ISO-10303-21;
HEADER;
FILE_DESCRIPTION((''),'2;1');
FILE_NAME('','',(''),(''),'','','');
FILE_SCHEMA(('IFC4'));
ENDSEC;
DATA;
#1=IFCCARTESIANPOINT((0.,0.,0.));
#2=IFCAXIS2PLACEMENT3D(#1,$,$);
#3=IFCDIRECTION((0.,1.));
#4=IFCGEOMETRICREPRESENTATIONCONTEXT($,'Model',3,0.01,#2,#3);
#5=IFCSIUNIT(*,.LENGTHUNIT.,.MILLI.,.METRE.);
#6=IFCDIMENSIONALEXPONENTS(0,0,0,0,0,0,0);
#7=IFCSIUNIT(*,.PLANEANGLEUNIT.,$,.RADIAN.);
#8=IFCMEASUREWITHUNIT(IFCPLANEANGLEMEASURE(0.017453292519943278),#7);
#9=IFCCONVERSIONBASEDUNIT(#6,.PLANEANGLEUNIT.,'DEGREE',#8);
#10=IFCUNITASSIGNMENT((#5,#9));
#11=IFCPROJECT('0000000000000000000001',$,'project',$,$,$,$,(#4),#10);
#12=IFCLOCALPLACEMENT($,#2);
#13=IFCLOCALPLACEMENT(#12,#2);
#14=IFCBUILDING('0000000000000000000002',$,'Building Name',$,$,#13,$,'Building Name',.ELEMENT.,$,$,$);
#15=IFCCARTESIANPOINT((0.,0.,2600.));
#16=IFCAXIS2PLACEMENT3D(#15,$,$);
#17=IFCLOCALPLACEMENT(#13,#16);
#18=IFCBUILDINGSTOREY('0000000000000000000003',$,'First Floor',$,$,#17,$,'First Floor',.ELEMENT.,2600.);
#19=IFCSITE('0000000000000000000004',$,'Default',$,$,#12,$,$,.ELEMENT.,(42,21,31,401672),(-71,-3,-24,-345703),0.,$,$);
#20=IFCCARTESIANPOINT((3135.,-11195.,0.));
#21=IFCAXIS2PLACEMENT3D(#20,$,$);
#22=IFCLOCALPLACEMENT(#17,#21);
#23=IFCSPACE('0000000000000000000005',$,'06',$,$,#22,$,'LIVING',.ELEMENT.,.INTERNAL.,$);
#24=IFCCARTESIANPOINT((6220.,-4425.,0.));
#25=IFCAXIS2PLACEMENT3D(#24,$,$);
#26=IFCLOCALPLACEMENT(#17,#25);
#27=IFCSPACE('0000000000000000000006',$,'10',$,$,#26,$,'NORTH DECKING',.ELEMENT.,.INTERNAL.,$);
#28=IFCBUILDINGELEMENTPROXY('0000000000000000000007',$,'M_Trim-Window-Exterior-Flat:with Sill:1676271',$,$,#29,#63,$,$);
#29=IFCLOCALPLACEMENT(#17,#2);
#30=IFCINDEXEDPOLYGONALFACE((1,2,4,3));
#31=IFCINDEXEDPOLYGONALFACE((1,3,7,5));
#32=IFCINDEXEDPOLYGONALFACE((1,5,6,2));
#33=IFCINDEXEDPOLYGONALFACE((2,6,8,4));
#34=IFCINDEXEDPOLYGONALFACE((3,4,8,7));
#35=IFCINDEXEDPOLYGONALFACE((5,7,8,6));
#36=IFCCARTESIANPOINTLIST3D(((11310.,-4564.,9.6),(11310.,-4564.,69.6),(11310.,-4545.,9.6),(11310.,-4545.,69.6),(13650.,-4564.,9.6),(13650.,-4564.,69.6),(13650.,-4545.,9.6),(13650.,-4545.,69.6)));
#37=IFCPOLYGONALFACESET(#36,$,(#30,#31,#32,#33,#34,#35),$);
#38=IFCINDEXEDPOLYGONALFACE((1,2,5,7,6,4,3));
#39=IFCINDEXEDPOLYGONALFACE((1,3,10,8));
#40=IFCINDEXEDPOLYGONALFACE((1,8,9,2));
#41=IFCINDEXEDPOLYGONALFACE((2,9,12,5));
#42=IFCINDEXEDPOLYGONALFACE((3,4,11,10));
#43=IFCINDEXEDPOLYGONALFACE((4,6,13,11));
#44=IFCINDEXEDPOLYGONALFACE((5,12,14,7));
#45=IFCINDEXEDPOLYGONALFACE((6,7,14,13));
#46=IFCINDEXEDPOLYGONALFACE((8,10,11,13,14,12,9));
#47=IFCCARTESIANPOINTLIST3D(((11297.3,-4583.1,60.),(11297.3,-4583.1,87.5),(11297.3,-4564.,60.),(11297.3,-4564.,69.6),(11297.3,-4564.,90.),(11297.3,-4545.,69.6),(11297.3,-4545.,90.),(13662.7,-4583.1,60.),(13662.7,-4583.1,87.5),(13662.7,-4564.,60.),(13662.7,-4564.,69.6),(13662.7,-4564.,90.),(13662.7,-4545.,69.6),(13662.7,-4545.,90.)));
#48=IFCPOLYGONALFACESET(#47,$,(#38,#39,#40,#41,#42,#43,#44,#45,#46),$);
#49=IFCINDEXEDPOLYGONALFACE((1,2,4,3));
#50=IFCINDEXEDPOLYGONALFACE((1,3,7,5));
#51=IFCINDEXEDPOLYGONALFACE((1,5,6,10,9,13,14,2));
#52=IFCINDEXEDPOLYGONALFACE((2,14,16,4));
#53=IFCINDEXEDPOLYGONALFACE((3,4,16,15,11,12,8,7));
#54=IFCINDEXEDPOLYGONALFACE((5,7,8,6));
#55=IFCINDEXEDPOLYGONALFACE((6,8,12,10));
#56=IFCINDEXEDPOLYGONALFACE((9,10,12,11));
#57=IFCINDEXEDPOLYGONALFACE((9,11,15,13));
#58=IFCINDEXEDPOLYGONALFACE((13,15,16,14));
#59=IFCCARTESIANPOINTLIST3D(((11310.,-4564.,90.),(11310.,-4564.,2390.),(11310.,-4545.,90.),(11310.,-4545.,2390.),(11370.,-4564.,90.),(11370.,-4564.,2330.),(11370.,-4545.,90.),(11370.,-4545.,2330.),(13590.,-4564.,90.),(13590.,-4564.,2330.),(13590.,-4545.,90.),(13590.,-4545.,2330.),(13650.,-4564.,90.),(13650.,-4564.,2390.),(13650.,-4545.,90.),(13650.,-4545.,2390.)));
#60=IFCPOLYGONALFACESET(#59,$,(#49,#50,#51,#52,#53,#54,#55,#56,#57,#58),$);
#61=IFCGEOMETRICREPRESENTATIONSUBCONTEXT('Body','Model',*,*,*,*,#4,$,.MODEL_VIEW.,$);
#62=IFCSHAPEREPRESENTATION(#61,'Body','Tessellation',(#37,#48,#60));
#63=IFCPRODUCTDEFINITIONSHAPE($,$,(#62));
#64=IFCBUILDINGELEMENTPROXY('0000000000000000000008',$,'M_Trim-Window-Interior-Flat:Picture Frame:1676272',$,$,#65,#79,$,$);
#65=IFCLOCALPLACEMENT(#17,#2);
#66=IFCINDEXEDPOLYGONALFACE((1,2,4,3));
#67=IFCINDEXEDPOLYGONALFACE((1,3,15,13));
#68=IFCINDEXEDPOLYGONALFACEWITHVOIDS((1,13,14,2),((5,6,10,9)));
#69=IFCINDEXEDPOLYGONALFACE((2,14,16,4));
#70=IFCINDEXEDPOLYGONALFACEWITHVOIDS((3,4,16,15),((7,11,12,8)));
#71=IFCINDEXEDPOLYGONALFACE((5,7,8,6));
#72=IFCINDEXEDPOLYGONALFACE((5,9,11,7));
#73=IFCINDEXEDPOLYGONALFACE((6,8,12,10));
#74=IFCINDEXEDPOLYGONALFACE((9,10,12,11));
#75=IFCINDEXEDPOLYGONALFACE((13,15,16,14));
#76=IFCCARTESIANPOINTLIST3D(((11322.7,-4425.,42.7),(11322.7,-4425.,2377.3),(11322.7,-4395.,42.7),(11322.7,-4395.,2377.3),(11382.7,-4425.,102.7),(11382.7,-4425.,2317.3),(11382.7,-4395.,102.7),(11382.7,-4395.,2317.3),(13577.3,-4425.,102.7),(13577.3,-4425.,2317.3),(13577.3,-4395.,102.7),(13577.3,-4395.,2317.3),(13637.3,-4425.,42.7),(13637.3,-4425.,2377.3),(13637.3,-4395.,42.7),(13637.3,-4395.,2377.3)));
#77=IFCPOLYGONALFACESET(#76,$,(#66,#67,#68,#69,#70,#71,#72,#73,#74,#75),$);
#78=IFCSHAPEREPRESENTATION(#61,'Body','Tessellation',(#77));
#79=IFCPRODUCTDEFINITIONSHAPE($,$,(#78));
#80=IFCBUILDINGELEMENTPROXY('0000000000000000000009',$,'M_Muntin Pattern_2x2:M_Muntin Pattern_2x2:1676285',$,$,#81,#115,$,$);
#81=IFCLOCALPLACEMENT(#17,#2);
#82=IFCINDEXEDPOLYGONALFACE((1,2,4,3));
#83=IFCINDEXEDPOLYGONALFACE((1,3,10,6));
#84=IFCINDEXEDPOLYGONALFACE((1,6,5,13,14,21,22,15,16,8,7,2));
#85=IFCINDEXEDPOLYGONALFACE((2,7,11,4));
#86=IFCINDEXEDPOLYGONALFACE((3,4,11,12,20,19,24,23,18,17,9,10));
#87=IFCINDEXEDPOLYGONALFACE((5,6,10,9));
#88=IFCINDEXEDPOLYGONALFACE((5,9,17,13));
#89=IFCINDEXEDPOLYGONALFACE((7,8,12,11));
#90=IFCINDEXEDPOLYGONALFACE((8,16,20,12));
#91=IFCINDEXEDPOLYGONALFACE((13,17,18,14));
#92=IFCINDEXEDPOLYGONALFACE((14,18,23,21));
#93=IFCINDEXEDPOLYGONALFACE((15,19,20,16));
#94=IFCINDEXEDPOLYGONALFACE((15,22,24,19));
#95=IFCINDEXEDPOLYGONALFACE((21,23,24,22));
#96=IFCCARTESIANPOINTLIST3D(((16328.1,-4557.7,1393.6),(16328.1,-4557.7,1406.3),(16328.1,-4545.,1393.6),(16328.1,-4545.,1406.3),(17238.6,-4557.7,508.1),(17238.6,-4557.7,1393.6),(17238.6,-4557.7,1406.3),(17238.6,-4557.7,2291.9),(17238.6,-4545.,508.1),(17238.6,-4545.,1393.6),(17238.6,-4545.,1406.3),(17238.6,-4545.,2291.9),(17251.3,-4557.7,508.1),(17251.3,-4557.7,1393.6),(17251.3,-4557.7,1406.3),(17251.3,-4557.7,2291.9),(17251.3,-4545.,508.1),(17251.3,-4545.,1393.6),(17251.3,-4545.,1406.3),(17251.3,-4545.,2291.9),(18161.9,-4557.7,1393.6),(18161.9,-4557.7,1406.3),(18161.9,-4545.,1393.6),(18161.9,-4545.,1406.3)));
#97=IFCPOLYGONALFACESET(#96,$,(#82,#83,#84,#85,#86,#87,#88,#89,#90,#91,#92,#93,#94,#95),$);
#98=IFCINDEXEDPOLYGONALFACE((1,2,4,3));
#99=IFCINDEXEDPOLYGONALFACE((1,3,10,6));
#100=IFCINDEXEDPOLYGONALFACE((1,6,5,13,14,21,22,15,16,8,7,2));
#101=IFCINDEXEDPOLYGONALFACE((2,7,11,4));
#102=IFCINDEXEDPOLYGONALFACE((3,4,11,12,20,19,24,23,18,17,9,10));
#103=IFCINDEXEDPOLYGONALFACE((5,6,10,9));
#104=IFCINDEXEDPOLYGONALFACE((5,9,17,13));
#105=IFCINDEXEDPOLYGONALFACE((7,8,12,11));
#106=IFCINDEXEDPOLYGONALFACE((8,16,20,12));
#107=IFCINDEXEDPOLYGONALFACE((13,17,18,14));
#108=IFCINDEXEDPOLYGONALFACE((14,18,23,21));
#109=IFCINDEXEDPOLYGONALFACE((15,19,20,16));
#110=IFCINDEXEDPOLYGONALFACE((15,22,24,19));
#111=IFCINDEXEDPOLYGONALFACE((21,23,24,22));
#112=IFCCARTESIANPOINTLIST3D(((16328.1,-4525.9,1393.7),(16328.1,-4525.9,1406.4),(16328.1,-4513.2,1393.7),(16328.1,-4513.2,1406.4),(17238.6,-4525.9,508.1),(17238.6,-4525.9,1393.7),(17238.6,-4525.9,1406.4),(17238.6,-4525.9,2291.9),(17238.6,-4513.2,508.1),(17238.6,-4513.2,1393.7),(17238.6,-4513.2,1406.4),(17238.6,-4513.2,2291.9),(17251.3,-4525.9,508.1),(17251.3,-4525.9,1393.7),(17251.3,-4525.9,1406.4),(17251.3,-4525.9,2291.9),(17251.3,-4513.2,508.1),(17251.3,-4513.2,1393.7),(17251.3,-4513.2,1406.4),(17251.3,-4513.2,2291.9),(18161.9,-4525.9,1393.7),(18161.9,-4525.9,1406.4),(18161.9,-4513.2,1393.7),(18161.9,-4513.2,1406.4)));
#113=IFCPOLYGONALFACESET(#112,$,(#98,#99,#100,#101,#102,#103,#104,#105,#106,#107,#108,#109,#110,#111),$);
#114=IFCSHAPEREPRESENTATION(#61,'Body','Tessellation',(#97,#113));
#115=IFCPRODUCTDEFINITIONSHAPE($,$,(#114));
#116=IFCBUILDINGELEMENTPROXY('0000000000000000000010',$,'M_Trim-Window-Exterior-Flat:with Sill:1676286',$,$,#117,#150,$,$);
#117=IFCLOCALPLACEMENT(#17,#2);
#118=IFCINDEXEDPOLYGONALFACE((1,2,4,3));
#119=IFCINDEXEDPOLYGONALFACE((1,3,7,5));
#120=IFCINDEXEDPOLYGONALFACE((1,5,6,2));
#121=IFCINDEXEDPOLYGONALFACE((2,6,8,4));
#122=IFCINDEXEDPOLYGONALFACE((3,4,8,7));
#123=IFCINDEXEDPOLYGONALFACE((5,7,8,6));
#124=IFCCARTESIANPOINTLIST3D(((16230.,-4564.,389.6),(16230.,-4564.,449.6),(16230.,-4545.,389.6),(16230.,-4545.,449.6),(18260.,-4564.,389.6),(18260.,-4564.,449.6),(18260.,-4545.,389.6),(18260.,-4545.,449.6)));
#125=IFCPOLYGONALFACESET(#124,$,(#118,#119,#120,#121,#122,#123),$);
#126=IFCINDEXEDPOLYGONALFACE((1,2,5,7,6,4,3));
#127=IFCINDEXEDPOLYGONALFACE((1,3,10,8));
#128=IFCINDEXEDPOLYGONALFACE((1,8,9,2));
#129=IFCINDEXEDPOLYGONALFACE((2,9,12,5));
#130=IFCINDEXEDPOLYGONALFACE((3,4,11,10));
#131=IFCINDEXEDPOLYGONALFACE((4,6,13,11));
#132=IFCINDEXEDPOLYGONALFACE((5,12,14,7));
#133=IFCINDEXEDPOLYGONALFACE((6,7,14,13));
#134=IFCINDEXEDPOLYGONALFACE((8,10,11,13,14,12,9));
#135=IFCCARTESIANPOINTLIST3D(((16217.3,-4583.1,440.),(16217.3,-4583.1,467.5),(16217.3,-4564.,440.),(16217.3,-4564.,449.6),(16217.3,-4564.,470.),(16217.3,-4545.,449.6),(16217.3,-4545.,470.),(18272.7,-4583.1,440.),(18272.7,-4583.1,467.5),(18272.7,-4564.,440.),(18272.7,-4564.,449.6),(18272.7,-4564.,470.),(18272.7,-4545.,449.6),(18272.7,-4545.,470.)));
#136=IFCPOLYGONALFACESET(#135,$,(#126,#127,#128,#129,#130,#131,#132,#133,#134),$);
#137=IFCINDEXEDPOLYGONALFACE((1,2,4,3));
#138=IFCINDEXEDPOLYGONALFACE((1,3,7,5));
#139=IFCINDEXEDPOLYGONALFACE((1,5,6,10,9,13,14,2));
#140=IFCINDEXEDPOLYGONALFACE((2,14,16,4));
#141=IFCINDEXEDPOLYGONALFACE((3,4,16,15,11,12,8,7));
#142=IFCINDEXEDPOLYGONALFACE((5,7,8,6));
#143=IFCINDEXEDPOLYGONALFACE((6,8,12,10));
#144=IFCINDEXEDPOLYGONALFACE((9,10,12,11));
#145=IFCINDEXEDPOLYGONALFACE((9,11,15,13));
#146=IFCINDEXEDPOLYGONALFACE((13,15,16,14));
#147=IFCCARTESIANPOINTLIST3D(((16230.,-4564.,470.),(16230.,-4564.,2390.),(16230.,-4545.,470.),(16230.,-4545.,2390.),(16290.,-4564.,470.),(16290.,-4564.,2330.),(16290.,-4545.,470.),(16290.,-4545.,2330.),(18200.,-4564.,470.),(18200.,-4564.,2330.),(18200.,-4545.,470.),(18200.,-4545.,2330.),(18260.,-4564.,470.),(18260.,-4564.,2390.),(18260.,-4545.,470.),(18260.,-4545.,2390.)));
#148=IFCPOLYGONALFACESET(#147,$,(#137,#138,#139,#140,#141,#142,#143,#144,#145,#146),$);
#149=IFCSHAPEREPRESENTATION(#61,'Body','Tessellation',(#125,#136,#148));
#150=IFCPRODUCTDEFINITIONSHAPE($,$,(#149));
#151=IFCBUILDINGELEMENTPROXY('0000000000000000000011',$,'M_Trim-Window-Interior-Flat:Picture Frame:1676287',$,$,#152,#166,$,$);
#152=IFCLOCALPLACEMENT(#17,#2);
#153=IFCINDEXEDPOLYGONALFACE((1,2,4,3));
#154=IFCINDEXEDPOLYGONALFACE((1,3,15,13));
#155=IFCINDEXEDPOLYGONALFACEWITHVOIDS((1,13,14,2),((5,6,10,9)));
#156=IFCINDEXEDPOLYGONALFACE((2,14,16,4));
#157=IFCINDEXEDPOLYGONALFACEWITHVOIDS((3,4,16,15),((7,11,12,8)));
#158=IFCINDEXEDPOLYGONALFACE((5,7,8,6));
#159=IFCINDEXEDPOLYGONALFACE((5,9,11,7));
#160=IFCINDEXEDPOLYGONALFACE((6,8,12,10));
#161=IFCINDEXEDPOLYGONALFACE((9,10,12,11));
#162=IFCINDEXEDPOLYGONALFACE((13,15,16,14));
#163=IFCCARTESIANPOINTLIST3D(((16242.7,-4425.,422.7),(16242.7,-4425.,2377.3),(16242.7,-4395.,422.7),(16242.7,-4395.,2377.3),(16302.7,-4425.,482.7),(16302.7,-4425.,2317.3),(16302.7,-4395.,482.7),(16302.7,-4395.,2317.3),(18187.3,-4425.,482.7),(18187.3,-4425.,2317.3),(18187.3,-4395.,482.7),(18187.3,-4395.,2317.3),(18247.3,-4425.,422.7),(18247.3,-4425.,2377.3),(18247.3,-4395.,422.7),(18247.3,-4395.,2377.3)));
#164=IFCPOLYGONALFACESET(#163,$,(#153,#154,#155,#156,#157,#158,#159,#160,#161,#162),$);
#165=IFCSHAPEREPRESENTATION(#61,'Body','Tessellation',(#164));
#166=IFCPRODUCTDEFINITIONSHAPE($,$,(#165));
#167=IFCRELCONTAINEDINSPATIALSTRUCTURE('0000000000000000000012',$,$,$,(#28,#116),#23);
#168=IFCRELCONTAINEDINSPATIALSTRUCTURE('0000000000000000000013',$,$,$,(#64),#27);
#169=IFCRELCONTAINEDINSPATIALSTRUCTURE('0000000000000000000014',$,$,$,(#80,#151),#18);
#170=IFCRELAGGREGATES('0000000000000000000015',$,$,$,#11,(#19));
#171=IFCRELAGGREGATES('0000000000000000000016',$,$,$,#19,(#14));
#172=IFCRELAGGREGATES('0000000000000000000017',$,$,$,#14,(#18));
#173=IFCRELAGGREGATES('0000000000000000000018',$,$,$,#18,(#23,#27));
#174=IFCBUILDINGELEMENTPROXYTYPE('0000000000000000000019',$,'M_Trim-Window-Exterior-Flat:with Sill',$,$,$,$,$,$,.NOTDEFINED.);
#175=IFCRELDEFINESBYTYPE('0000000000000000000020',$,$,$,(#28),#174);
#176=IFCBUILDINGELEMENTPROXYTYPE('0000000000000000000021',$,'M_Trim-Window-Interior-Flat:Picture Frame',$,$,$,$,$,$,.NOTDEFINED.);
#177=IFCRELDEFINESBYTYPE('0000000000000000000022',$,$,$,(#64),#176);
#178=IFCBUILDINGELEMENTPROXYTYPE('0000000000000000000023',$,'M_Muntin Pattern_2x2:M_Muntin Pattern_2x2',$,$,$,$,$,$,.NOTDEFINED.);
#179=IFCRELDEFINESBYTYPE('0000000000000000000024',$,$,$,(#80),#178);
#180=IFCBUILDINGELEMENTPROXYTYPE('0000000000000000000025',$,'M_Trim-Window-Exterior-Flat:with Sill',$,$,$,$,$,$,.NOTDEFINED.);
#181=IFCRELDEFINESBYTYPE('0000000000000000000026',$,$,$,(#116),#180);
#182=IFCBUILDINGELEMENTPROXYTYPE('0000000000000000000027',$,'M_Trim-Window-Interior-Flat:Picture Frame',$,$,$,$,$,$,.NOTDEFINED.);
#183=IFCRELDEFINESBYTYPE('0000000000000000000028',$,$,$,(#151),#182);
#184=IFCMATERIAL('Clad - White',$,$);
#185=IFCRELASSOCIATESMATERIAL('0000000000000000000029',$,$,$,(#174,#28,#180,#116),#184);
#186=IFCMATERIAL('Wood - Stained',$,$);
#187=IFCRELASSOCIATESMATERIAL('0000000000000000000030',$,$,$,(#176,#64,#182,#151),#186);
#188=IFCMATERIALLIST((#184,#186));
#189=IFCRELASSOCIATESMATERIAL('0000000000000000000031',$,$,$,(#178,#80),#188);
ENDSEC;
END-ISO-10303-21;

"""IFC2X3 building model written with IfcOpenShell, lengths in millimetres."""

from ifc_helpers import new_model, entity, si_unit, converted_unit, direction, frame, frame_2d, origin, place, context, subcontext, project, spatial, polyline, rectangle, outline, extrude, source, transform, mapped, material, material_list, type_object, type_shapes, element, save


model = new_model("IFC2X3")

# Units and contexts
model_context = context("Model", 3, precision=0.01, world=origin(), true_north=direction((0.0, 1.0)))
body_context = subcontext(model_context, "Body", "Model", "MODEL_VIEW")
ifc_project = project(units=[si_unit("LENGTHUNIT", "METRE", prefix="MILLI"), converted_unit("PLANEANGLEUNIT", "DEGREE", entity("IfcPlaneAngleMeasure", 0.017453292519943278), si_unit("PLANEANGLEUNIT", "RADIAN"), dimensions=[0, 0, 0, 0, 0, 0, 0])], contexts=[model_context])

# Site, building, storey
site_placement = place(None, origin())
site = spatial("IfcSite", under=ifc_project, at=site_placement, Name="Default", CompositionType="ELEMENT", RefLatitude=(42, 21, 31, 401672), RefLongitude=(-71, -3, -24, -345703), RefElevation=0.0)
building_placement = place(site_placement, origin())
building = spatial("IfcBuilding", under=site, at=building_placement, Name="Building Name", LongName="Building Name", CompositionType="ELEMENT")
storey_placement = place(building_placement, frame((0.0, 0.0, 2600.0)))
storey = spatial("IfcBuildingStorey", under=building, at=storey_placement, Name="First Floor", LongName="First Floor", CompositionType="ELEMENT", Elevation=2600.0)

# Shared definitions
space_1_placement = place(storey_placement, frame((3135.0, -11195.0, 0.0)))
space_1 = spatial("IfcSpace", under=storey, at=space_1_placement, Name="06", LongName="LIVING", CompositionType="ELEMENT", InteriorOrExteriorSpace="INTERNAL")

# Shared definitions
ifc_material_1 = material(Name="Clad - White")
ifc_material_2 = material(Name="Wood - Stained")
ifc_material_list_1 = material_list([ifc_material_1, ifc_material_2])

# Shared definitions
space_2_placement = place(storey_placement, frame((6220.0, -4425.0, 0.0)))
space_2 = spatial("IfcSpace", under=storey, at=space_2_placement, Name="10", LongName="NORTH DECKING", CompositionType="ELEMENT", InteriorOrExteriorSpace="INTERNAL")

# Building element proxies
building_element_proxy_type_1 = type_object("IfcBuildingElementProxyType", Name="M_Trim-Window-Exterior-Flat:with Sill", PredefinedType="NOTDEFINED", material=ifc_material_1)
shared_shape_1 = source(origin(), body_context, "Body", "SweptSolid", [
    extrude(rectangle(XDim=2340.0, YDim=60.0, at=frame_2d((0.0, 0.0), x_axis=(1.0, 0.0))), frame((0.0, -2290.4, 0.0), z_axis=(0.0, 0.0, 1.0), x_axis=(-1.0, 0.0, 0.0)), (0.0, 0.0, 1.0), 19.0),
    extrude(outline(polyline([(-19.0, -15.2), (0.0, -15.2), (0.0, -5.7), (19.0, -5.7), (19.0, 14.8), (0.0, 14.8), (-19.0, 12.3), (-19.0, -15.2)])), frame((-1182.7, -2254.8, 19.0), z_axis=(1.0, 0.0, 0.0), x_axis=(0.0, 0.0, -1.0)), (0.0, 0.0, 1.0), 2365.4),
    extrude(outline(polyline([(-1165.0, -1170.0), (1135.0, -1170.0), (1135.0, -1110.0), (-1105.0, -1110.0), (-1105.0, 1110.0), (1135.0, 1110.0), (1135.0, 1170.0), (-1165.0, 1170.0), (-1165.0, -1170.0)])), frame((0.0, -1105.0, 0.0), z_axis=(0.0, 0.0, 1.0), x_axis=(0.0, -1.0, 0.0)), (0.0, 0.0, 1.0), 19.0),
])
type_shapes(building_element_proxy_type_1, [shared_shape_1])
proxy_1_placement = place(space_1_placement, frame((9345.0, 6650.0, 2330.0), z_axis=(0.0, -1.0, 0.0), x_axis=(1.0, 0.0, 0.0)))
element("IfcBuildingElementProxy", 1, at=proxy_1_placement, inside=space_1, type_object=building_element_proxy_type_1, material=ifc_material_1, Name="M_Trim-Window-Exterior-Flat:with Sill:1676271", context=body_context, shape_type="MappedRepresentation", body=[
    mapped(shared_shape_1, transform((0.0, 0.0, 0.0), scale=1.0)),
])
building_element_proxy_type_2 = type_object("IfcBuildingElementProxyType", Name="M_Trim-Window-Interior-Flat:Picture Frame", PredefinedType="NOTDEFINED", material=ifc_material_2)
shared_shape_2 = source(origin(), body_context, "Body", "SweptSolid", [
    extrude(outline(polyline([(-1157.3, -1167.3), (1157.3, -1167.3), (1157.3, 1167.3), (-1157.3, 1167.3), (-1157.3, -1167.3)]), holes=[polyline([(-1097.3, -1107.3), (-1097.3, 1107.3), (1097.3, 1107.3), (1097.3, -1107.3), (-1097.3, -1107.3)])]), frame((0.0, -1120.0, 0.0), z_axis=(0.0, 0.0, 1.0), x_axis=(-1.0, 0.0, 0.0)), (0.0, 0.0, 1.0), 30.0),
])
type_shapes(building_element_proxy_type_2, [shared_shape_2])
proxy_2_placement = place(space_2_placement, frame((6260.0, 0.0, 2330.0), z_axis=(0.0, 1.0, 0.0), x_axis=(-1.0, 0.0, 0.0)))
element("IfcBuildingElementProxy", 2, at=proxy_2_placement, inside=space_2, type_object=building_element_proxy_type_2, material=ifc_material_2, Name="M_Trim-Window-Interior-Flat:Picture Frame:1676272", context=body_context, shape_type="MappedRepresentation", body=[
    mapped(shared_shape_2, transform((0.0, 0.0, 0.0), scale=1.0)),
])
building_element_proxy_type_3 = type_object("IfcBuildingElementProxyType", Name="M_Muntin Pattern_2x2:M_Muntin Pattern_2x2", PredefinedType="NOTDEFINED", material=ifc_material_list_1)
shared_shape_3 = source(origin(), body_context, "Body", "SweptSolid", [
    extrude(outline(polyline([(6.4, -6.4), (891.9, -6.4), (891.9, 6.3), (6.4, 6.3), (6.4, 916.9), (-6.3, 916.9), (-6.3, 6.3), (-891.9, 6.3), (-891.9, -6.4), (-6.3, -6.4), (-6.3, -916.9), (6.4, -916.9), (6.4, -6.4)])), frame((0.0, -22.2, 891.9), z_axis=(0.0, 1.0, 0.0), x_axis=(0.0, 0.0, 1.0)), (0.0, 0.0, 1.0), 12.7),
    extrude(outline(polyline([(6.4, -6.4), (891.9, -6.4), (891.9, 6.3), (6.4, 6.3), (6.4, 916.9), (-6.3, 916.9), (-6.3, 6.3), (-891.9, 6.3), (-891.9, -6.4), (-6.3, -6.4), (-6.3, -916.9), (6.4, -916.9), (6.4, -6.4)])), frame((0.0, 9.5, 891.9), z_axis=(0.0, 1.0, 0.0), x_axis=(0.0, 0.0, 1.0)), (0.0, 0.0, 1.0), 12.7),
])
type_shapes(building_element_proxy_type_3, [shared_shape_3])
proxy_3_placement = place(storey_placement, frame((17245.0, -4535.5, 508.1)))
element("IfcBuildingElementProxy", 3, at=proxy_3_placement, inside=storey, type_object=building_element_proxy_type_3, material=ifc_material_list_1, Name="M_Muntin Pattern_2x2:M_Muntin Pattern_2x2:1676285", context=body_context, shape_type="MappedRepresentation", body=[
    mapped(shared_shape_3, transform((0.0, 0.0, 0.0), scale=1.0)),
])
building_element_proxy_type_4 = type_object("IfcBuildingElementProxyType", Name="M_Trim-Window-Exterior-Flat:with Sill", PredefinedType="NOTDEFINED", material=ifc_material_1)
shared_shape_4 = source(origin(), body_context, "Body", "SweptSolid", [
    extrude(rectangle(XDim=2030.0, YDim=60.0, at=frame_2d((0.0, 0.0), x_axis=(1.0, 0.0))), frame((0.0, -1910.4, 0.0), z_axis=(0.0, 0.0, 1.0), x_axis=(-1.0, 0.0, 0.0)), (0.0, 0.0, 1.0), 19.0),
    extrude(outline(polyline([(-19.0, -15.2), (0.0, -15.2), (0.0, -5.7), (19.0, -5.7), (19.0, 14.8), (0.0, 14.8), (-19.0, 12.3), (-19.0, -15.2)])), frame((-1027.7, -1874.8, 19.0), z_axis=(1.0, 0.0, 0.0), x_axis=(0.0, 0.0, -1.0)), (0.0, 0.0, 1.0), 2055.4),
    extrude(outline(polyline([(-975.0, -1015.0), (945.0, -1015.0), (945.0, -955.0), (-915.0, -955.0), (-915.0, 955.0), (945.0, 955.0), (945.0, 1015.0), (-975.0, 1015.0), (-975.0, -1015.0)])), frame((0.0, -915.0, 0.0), z_axis=(0.0, 0.0, 1.0), x_axis=(0.0, -1.0, 0.0)), (0.0, 0.0, 1.0), 19.0),
])
type_shapes(building_element_proxy_type_4, [shared_shape_4])
proxy_4_placement = place(space_1_placement, frame((14110.0, 6650.0, 2330.0), z_axis=(0.0, -1.0, 0.0), x_axis=(1.0, 0.0, 0.0)))
element("IfcBuildingElementProxy", 4, at=proxy_4_placement, inside=space_1, type_object=building_element_proxy_type_4, material=ifc_material_1, Name="M_Trim-Window-Exterior-Flat:with Sill:1676286", context=body_context, shape_type="MappedRepresentation", body=[
    mapped(shared_shape_4, transform((0.0, 0.0, 0.0), scale=1.0)),
])
building_element_proxy_type_5 = type_object("IfcBuildingElementProxyType", Name="M_Trim-Window-Interior-Flat:Picture Frame", PredefinedType="NOTDEFINED", material=ifc_material_2)
shared_shape_5 = source(origin(), body_context, "Body", "SweptSolid", [
    extrude(outline(polyline([(-1002.3, -977.3), (1002.3, -977.3), (1002.3, 977.3), (-1002.3, 977.3), (-1002.3, -977.3)]), holes=[polyline([(-942.3, -917.3), (-942.3, 917.3), (942.3, 917.3), (942.3, -917.3), (-942.3, -917.3)])]), frame((0.0, -930.0, 0.0), z_axis=(0.0, 0.0, 1.0), x_axis=(-1.0, 0.0, 0.0)), (0.0, 0.0, 1.0), 30.0),
])
type_shapes(building_element_proxy_type_5, [shared_shape_5])
proxy_5_placement = place(storey_placement, frame((17245.0, -4425.0, 2330.0), z_axis=(0.0, 1.0, 0.0), x_axis=(-1.0, 0.0, 0.0)))
element("IfcBuildingElementProxy", 5, at=proxy_5_placement, inside=storey, type_object=building_element_proxy_type_5, material=ifc_material_2, Name="M_Trim-Window-Interior-Flat:Picture Frame:1676287", context=body_context, shape_type="MappedRepresentation", body=[
    mapped(shared_shape_5, transform((0.0, 0.0, 0.0), scale=1.0)),
])

save(model, "model.ifc")
